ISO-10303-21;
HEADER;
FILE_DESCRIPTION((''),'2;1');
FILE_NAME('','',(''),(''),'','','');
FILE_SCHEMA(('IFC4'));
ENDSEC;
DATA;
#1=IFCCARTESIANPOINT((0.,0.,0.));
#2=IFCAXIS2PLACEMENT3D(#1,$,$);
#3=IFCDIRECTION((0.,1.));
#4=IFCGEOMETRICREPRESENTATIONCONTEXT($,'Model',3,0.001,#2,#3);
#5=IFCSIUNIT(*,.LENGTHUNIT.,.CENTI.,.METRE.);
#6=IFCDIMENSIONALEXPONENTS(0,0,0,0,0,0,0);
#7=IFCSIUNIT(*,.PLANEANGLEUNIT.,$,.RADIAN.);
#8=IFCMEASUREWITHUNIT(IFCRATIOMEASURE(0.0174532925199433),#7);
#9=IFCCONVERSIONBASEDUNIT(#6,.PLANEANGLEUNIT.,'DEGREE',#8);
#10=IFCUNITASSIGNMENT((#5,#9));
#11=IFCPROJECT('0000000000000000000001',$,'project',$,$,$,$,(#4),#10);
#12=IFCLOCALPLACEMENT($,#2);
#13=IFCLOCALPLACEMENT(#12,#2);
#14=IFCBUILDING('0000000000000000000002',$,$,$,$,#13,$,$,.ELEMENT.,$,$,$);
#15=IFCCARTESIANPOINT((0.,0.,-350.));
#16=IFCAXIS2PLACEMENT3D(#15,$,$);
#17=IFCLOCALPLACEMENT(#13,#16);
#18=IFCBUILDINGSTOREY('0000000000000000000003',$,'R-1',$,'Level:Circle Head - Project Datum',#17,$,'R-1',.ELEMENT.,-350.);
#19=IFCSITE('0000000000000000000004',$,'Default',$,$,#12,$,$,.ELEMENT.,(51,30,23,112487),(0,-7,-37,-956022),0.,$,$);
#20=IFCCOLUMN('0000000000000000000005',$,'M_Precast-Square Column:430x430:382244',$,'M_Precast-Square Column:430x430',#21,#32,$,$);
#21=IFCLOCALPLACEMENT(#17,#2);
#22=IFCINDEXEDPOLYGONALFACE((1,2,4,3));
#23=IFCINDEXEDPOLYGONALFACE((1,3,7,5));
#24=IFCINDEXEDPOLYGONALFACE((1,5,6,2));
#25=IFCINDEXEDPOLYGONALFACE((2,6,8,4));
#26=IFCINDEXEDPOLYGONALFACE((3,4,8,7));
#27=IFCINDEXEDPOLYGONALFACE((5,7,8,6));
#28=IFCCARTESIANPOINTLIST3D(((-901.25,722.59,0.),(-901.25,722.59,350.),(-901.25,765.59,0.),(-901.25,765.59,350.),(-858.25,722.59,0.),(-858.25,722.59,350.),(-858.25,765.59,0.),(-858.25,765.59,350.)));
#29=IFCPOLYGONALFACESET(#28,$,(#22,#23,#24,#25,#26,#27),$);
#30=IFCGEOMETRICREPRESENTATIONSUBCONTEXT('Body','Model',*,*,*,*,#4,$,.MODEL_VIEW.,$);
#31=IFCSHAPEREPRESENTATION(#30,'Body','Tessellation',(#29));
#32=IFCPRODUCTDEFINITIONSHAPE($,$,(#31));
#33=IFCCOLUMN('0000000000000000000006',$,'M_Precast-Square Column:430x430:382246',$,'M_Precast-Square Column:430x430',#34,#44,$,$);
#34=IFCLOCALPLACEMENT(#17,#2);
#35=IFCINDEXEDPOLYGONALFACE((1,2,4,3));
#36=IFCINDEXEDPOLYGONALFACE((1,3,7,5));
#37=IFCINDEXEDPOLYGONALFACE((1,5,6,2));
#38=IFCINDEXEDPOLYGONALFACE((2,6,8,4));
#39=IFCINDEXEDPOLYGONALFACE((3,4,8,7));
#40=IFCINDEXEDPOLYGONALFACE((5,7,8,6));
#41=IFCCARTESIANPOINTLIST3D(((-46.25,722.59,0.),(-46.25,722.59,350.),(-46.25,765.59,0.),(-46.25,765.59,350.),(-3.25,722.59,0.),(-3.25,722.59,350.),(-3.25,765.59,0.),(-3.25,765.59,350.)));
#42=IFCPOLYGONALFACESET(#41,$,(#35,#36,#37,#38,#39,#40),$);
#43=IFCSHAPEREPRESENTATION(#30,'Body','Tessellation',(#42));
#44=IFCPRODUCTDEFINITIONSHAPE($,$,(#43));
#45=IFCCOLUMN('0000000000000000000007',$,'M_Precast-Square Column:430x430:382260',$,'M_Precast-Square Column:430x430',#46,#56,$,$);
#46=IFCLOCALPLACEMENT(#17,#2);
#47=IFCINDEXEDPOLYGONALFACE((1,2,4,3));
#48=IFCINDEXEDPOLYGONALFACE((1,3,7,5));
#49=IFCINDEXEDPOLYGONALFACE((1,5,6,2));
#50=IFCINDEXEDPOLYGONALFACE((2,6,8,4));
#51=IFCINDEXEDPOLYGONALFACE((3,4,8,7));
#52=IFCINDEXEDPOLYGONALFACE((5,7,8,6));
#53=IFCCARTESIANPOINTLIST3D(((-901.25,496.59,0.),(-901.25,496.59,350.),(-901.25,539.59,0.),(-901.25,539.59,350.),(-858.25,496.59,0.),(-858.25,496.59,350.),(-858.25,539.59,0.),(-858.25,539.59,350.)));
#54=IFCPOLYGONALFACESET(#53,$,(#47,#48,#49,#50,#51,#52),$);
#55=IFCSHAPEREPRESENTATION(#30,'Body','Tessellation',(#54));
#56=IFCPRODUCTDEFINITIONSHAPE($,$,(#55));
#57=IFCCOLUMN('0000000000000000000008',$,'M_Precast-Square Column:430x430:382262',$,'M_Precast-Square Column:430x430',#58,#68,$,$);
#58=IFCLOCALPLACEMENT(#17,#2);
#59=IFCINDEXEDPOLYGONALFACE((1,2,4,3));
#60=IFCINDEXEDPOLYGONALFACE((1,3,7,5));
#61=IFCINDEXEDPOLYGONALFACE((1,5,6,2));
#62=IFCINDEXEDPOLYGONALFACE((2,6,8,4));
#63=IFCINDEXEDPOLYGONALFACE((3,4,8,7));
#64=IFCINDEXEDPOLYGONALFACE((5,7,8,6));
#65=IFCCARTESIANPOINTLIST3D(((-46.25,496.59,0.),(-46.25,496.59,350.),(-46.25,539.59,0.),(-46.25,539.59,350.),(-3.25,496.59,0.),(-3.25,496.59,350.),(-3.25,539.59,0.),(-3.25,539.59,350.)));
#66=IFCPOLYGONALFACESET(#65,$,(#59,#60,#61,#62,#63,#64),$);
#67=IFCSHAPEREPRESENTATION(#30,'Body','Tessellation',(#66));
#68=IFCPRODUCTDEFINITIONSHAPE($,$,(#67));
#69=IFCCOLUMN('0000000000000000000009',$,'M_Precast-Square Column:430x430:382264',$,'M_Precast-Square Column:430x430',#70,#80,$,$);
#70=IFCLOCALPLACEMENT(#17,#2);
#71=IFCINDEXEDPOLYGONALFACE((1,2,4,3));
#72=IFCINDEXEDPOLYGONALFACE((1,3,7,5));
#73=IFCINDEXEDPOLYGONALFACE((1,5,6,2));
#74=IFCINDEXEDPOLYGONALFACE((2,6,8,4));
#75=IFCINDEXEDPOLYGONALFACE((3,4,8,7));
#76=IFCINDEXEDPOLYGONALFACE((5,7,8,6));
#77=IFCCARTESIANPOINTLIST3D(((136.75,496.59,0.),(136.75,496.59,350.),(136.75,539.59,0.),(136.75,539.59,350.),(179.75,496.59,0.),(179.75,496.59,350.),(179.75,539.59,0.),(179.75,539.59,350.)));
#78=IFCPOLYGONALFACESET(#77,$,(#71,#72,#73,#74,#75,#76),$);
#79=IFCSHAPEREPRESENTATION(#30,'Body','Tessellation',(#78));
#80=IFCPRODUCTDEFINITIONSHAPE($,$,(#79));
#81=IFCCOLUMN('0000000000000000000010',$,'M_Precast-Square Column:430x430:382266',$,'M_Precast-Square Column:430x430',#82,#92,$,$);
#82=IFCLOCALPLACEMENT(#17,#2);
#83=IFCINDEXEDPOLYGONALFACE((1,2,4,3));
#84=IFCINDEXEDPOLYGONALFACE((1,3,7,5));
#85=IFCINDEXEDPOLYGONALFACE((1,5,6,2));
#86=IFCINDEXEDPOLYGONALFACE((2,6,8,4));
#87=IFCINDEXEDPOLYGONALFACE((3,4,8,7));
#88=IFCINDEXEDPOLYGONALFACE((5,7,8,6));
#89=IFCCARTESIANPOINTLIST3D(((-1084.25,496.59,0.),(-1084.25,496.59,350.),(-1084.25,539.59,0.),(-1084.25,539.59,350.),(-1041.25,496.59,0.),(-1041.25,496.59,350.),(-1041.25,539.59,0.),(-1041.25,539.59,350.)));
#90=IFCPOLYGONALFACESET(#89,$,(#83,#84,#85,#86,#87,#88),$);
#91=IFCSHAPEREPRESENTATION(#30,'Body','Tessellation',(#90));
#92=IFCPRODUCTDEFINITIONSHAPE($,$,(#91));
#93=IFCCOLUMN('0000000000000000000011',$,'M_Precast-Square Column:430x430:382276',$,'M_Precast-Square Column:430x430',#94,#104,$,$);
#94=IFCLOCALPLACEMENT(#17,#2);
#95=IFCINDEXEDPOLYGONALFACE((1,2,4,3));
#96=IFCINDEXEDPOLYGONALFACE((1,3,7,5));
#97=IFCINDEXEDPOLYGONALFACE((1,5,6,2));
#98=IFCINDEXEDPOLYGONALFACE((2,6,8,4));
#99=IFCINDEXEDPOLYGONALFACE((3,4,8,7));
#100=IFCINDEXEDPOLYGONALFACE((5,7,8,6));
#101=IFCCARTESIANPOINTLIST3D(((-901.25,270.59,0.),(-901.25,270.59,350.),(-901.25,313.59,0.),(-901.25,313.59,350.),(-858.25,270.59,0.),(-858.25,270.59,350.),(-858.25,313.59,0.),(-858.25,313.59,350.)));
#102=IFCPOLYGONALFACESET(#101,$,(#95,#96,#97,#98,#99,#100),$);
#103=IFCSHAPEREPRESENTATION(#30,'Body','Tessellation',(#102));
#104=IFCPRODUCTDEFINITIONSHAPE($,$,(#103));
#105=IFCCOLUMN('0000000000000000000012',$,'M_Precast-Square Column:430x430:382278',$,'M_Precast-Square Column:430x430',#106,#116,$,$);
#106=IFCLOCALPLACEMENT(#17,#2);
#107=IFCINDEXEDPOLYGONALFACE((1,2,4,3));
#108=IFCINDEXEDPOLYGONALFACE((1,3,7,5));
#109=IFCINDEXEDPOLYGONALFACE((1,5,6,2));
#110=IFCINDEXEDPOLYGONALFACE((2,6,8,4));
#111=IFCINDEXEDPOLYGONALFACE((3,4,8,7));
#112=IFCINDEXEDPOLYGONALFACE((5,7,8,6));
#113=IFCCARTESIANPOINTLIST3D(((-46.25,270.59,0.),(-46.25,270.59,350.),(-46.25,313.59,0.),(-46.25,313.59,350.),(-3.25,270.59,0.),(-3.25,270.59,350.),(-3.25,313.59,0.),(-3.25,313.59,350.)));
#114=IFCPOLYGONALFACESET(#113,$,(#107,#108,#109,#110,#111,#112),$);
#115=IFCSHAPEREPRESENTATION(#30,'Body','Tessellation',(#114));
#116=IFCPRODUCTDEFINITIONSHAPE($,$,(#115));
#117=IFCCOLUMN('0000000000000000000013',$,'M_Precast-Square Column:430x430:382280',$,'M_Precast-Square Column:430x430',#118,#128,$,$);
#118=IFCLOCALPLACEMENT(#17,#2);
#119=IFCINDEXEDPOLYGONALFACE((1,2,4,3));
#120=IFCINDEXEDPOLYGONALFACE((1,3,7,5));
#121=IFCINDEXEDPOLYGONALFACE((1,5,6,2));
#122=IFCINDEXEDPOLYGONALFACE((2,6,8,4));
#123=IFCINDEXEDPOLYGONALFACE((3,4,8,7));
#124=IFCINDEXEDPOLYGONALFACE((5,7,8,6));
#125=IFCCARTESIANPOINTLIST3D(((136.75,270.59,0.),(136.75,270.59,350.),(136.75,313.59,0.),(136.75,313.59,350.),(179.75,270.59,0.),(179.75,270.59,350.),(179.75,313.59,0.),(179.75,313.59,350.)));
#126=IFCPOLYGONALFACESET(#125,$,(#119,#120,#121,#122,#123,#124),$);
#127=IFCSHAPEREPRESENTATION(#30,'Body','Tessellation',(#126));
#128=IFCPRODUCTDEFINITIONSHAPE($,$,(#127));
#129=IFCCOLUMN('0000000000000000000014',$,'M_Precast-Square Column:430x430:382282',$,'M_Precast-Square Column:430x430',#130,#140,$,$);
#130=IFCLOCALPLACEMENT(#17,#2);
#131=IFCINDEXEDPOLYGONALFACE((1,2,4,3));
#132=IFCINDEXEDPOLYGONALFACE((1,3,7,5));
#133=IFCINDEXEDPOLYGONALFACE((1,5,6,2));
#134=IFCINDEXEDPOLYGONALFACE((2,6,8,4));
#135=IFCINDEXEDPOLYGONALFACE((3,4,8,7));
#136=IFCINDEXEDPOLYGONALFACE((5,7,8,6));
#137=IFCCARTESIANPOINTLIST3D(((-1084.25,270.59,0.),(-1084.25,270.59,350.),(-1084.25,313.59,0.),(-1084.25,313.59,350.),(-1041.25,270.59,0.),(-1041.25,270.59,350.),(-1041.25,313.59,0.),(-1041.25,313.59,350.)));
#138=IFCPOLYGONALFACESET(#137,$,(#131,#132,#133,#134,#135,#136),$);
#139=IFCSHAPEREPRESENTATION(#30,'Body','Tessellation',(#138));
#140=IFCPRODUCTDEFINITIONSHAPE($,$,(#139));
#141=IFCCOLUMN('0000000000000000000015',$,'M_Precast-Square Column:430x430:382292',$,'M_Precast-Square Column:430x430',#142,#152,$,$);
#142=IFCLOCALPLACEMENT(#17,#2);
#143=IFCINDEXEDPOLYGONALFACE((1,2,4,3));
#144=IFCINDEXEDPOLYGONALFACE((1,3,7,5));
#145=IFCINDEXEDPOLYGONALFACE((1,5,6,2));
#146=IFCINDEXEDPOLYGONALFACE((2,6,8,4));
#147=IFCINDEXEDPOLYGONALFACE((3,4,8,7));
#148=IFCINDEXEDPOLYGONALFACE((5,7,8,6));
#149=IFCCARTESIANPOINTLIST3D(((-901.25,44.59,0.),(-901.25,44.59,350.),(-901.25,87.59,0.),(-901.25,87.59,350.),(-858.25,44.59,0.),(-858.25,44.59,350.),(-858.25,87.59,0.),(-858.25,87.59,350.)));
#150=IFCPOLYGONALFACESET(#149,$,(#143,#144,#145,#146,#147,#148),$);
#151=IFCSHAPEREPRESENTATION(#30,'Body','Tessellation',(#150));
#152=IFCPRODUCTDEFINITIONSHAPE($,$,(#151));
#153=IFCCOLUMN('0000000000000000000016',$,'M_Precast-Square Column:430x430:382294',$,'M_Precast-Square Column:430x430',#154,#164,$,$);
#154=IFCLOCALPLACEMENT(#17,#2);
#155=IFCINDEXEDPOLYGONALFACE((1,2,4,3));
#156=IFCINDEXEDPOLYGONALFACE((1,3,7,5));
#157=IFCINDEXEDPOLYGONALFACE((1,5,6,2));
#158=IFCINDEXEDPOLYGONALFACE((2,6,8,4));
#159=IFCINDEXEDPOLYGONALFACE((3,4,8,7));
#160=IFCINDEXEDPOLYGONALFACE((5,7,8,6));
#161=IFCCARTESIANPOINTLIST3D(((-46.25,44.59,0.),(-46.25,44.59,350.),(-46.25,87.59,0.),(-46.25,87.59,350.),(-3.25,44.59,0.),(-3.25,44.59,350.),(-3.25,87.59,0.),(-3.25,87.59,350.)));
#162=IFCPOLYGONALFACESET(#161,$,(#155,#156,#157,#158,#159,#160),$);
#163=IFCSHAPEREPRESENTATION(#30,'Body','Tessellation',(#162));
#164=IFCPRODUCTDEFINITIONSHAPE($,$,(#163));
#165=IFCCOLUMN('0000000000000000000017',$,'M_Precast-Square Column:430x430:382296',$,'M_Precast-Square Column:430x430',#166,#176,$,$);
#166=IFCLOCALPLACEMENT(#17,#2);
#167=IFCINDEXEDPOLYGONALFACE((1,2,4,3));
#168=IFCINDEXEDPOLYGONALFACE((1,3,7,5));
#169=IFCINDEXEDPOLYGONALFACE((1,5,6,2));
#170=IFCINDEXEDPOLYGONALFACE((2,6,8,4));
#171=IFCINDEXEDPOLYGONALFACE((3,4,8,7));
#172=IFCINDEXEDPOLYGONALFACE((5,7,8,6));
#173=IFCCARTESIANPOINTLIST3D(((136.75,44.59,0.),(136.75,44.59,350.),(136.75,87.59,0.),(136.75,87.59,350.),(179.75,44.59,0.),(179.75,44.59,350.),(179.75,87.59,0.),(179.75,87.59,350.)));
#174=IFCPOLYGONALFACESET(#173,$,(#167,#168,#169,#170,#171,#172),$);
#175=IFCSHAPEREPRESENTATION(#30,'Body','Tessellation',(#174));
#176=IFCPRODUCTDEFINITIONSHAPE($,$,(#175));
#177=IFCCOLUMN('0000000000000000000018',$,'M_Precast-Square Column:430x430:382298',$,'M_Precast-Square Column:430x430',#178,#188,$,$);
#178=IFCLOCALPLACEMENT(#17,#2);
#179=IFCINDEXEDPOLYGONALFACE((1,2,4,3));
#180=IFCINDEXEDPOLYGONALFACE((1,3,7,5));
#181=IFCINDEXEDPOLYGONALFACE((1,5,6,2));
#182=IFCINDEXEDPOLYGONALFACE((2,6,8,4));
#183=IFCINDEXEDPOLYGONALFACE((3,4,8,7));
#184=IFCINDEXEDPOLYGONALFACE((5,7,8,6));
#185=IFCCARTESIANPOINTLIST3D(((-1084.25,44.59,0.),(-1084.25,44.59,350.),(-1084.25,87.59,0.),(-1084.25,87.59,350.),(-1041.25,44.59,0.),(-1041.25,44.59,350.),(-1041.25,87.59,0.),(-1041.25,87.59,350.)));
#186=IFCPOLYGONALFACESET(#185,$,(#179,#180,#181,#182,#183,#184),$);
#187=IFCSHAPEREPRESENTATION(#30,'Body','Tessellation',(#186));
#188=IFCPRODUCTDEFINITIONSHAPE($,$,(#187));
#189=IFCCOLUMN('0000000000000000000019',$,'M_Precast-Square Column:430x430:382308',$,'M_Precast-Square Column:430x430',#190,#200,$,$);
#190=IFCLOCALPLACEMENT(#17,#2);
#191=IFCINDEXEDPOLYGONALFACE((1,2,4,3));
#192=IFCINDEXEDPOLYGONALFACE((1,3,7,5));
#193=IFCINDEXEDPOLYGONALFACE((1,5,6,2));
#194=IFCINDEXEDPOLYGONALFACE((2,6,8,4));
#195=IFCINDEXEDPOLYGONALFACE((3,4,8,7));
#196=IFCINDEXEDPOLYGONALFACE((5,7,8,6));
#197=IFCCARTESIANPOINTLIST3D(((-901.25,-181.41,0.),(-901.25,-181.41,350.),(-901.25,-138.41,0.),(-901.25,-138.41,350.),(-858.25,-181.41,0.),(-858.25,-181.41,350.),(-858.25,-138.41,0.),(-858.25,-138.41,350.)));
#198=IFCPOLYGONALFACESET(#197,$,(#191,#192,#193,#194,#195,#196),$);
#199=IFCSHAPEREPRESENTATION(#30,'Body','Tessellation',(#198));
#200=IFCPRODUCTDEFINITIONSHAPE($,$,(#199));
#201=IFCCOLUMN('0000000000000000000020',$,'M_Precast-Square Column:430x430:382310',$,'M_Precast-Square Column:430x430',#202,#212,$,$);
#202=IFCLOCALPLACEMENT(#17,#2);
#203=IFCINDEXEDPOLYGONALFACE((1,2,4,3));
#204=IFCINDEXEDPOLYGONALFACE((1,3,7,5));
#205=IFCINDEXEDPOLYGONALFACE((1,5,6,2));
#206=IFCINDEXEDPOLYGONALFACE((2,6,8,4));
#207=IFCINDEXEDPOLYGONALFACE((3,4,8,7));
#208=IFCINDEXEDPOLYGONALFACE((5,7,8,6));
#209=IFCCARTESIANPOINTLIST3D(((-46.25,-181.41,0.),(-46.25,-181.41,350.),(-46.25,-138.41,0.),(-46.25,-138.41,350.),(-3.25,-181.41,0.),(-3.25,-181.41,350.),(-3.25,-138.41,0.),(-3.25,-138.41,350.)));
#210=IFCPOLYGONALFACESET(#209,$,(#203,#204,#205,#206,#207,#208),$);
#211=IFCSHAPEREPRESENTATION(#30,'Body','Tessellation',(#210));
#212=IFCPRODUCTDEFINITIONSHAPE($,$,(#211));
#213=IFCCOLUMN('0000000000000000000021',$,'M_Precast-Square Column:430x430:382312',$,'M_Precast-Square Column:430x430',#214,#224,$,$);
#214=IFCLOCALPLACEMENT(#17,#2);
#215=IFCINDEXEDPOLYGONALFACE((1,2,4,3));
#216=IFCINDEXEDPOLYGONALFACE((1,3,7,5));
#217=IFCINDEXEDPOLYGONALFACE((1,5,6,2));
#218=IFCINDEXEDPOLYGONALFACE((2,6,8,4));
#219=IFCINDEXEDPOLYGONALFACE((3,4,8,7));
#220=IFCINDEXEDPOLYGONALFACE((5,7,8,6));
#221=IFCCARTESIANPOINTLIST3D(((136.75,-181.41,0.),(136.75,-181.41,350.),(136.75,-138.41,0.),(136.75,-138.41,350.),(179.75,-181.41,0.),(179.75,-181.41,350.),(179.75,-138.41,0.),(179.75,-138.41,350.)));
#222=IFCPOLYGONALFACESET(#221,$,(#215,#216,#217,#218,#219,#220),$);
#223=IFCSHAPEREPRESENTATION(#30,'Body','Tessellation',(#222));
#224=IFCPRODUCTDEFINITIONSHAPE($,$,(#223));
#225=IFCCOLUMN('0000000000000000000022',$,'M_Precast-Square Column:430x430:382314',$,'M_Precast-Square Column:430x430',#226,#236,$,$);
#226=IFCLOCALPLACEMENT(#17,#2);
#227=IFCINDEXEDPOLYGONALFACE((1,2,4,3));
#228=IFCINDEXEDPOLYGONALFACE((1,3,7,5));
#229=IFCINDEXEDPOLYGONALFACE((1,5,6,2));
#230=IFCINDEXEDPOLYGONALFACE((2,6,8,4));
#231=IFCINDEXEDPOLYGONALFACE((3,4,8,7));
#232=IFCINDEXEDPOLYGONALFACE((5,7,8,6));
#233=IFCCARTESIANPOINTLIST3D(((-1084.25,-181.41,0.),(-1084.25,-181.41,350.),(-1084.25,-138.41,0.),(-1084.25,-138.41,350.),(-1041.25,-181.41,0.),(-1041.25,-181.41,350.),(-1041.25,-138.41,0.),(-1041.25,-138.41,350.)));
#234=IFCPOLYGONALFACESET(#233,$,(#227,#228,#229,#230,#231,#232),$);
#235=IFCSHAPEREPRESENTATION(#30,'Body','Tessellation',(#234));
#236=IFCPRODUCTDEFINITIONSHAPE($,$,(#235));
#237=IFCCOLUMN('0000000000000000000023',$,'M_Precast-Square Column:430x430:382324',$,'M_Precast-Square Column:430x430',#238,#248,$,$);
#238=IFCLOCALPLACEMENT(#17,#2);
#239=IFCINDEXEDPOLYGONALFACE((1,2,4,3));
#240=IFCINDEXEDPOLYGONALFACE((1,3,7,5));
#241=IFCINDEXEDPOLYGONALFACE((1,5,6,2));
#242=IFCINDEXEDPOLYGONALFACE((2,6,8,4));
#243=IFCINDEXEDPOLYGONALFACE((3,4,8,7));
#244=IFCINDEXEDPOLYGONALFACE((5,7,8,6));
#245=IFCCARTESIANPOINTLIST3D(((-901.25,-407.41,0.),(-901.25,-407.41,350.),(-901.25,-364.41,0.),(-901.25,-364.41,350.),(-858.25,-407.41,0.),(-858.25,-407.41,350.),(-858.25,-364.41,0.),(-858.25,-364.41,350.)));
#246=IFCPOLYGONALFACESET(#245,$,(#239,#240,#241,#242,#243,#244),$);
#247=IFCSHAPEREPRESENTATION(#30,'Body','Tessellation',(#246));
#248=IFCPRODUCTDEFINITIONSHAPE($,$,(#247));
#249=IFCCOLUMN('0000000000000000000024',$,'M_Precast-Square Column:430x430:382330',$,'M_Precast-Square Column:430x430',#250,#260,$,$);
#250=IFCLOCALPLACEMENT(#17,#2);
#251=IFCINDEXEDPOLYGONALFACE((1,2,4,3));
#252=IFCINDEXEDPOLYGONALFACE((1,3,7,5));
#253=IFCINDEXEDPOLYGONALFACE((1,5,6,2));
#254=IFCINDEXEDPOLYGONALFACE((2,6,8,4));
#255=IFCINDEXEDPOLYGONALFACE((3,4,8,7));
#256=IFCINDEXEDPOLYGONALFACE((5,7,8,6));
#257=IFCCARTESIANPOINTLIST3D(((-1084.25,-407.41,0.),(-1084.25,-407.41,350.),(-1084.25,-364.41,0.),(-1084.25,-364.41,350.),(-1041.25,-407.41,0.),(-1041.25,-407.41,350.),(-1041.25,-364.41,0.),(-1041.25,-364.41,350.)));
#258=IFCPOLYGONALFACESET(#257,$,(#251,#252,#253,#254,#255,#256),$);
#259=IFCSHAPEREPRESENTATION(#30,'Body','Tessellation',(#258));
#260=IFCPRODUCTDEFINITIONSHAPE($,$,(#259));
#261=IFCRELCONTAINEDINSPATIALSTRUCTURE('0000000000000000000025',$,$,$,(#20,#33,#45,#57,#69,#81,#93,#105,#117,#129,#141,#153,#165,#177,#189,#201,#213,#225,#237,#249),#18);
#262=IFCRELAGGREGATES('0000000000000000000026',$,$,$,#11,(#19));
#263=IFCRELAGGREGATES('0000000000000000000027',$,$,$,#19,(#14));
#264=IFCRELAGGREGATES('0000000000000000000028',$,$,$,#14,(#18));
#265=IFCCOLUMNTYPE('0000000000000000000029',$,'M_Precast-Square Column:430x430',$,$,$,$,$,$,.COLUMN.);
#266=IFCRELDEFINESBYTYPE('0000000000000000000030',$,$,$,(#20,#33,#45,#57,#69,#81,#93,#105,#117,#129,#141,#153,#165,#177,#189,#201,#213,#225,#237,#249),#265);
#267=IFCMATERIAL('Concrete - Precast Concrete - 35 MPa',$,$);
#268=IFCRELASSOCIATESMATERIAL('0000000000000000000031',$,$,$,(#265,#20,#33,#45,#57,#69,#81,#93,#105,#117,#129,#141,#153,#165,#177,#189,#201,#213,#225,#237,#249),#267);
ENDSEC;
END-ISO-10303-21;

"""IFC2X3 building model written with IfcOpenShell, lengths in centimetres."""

from ifc_helpers import new_model, entity, si_unit, converted_unit, direction, frame, origin, origin_2d_with_axis, place, context, subcontext, project, spatial, rectangle, extrude, source, transform, mapped, material, type_object, type_shapes, element, save


model = new_model("IFC2X3")

# Units and contexts
model_context = context("Model", 3, precision=0.001, world=origin(), true_north=direction((0.0, 1.0)))
body_context = subcontext(model_context, "Body", "Model", "MODEL_VIEW")
ifc_project = project(units=[si_unit("LENGTHUNIT", "METRE", prefix="CENTI"), converted_unit("PLANEANGLEUNIT", "DEGREE", entity("IfcRatioMeasure", 0.0174532925199433), si_unit("PLANEANGLEUNIT", "RADIAN"), dimensions=[0, 0, 0, 0, 0, 0, 0])], contexts=[model_context])

# Site, building, storey
site_placement = place(None, origin())
site = spatial("IfcSite", under=ifc_project, at=site_placement, Name="Default", CompositionType="ELEMENT", RefLatitude=(51, 30, 23, 112487), RefLongitude=(0, -7, -37, -956022), RefElevation=0.0)
building_placement = place(site_placement, origin())
building = spatial("IfcBuilding", under=site, at=building_placement, CompositionType="ELEMENT")
storey_placement = place(building_placement, frame((0.0, 0.0, -350.0)))
storey = spatial("IfcBuildingStorey", under=building, at=storey_placement, Name="R-1", ObjectType="Level:Circle Head - Project Datum", LongName="R-1", CompositionType="ELEMENT", Elevation=-350.0)

# Columns
ifc_material_1 = material(Name="Concrete - Precast Concrete - 35 MPa")
column_type = type_object("IfcColumnType", Name="M_Precast-Square Column:430x430", PredefinedType="COLUMN", material=ifc_material_1)
shared_shape = source(origin(), body_context, "Body", "SweptSolid", [
    extrude(rectangle(XDim=43.0, YDim=43.0, at=origin_2d_with_axis()), frame((0.0, 0.0, -350.0), z_axis=(0.0, 0.0, 1.0), x_axis=(0.0, -1.0, 0.0)), (0.0, 0.0, 1.0), 350.0),
])
type_shapes(column_type, [shared_shape])
for number, where, z_axis, x_axis, name in (
    (1, (-879.75, 744.09, 350.0), (0.0, 0.0, 1.0), (-1.0, 0.0, 0.0), "M_Precast-Square Column:430x430:382244"),
    (2, (-24.75, 744.09, 350.0), (0.0, 0.0, 1.0), (-1.0, 0.0, 0.0), "M_Precast-Square Column:430x430:382246"),
    (3, (-879.75, 518.09, 350.0), (0.0, 0.0, 1.0), (-1.0, 0.0, 0.0), "M_Precast-Square Column:430x430:382260"),
    (4, (-24.75, 518.09, 350.0), (0.0, 0.0, 1.0), (-1.0, 0.0, 0.0), "M_Precast-Square Column:430x430:382262"),
    (5, (158.25, 518.09, 350.0), (0.0, 0.0, 1.0), (-1.0, 0.0, 0.0), "M_Precast-Square Column:430x430:382264"),
    (6, (-1062.75, 518.09, 350.0), (0.0, 0.0, 1.0), (-1.0, 0.0, 0.0), "M_Precast-Square Column:430x430:382266"),
    (7, (-879.75, 292.09, 350.0), (0.0, 0.0, 1.0), (-1.0, 0.0, 0.0), "M_Precast-Square Column:430x430:382276"),
    (8, (-24.75, 292.09, 350.0), (0.0, 0.0, 1.0), (-1.0, 0.0, 0.0), "M_Precast-Square Column:430x430:382278"),
    (9, (158.25, 292.09, 350.0), (0.0, 0.0, 1.0), (-1.0, 0.0, 0.0), "M_Precast-Square Column:430x430:382280"),
    (10, (-1062.75, 292.09, 350.0), (0.0, 0.0, 1.0), (-1.0, 0.0, 0.0), "M_Precast-Square Column:430x430:382282"),
    (11, (-879.75, 66.09, 350.0), (0.0, 0.0, 1.0), (-1.0, 0.0, 0.0), "M_Precast-Square Column:430x430:382292"),
    (12, (-24.75, 66.09, 350.0), (0.0, 0.0, 1.0), (-1.0, 0.0, 0.0), "M_Precast-Square Column:430x430:382294"),
    (13, (158.25, 66.09, 350.0), (0.0, 0.0, 1.0), (-1.0, 0.0, 0.0), "M_Precast-Square Column:430x430:382296"),
    (14, (-1062.75, 66.09, 350.0), (0.0, 0.0, 1.0), (-1.0, 0.0, 0.0), "M_Precast-Square Column:430x430:382298"),
    (15, (-879.75, -159.91, 350.0), (0.0, 0.0, 1.0), (-1.0, 0.0, 0.0), "M_Precast-Square Column:430x430:382308"),
    (16, (-24.75, -159.91, 350.0), (0.0, 0.0, 1.0), (-1.0, 0.0, 0.0), "M_Precast-Square Column:430x430:382310"),
    (17, (158.25, -159.91, 350.0), (0.0, 0.0, 1.0), (-1.0, 0.0, 0.0), "M_Precast-Square Column:430x430:382312"),
    (18, (-1062.75, -159.91, 350.0), (0.0, 0.0, 1.0), (-1.0, 0.0, 0.0), "M_Precast-Square Column:430x430:382314"),
    (19, (-879.75, -385.91, 350.0), (0.0, 0.0, 1.0), (-1.0, 0.0, 0.0), "M_Precast-Square Column:430x430:382324"),
    (20, (-1062.75, -385.91, 350.0), (0.0, 0.0, 1.0), (-1.0, 0.0, 0.0), "M_Precast-Square Column:430x430:382330"),
):
    element("IfcColumn", number, at=place(storey_placement, frame(where, z_axis=z_axis, x_axis=x_axis)), inside=storey, type_object=column_type, material=ifc_material_1, Name=name, ObjectType="M_Precast-Square Column:430x430", context=body_context, shape_type="MappedRepresentation", body=[
        mapped(shared_shape, transform((0.0, 0.0, 0.0), scale=1.0)),
    ])

save(model, "model.ifc")
